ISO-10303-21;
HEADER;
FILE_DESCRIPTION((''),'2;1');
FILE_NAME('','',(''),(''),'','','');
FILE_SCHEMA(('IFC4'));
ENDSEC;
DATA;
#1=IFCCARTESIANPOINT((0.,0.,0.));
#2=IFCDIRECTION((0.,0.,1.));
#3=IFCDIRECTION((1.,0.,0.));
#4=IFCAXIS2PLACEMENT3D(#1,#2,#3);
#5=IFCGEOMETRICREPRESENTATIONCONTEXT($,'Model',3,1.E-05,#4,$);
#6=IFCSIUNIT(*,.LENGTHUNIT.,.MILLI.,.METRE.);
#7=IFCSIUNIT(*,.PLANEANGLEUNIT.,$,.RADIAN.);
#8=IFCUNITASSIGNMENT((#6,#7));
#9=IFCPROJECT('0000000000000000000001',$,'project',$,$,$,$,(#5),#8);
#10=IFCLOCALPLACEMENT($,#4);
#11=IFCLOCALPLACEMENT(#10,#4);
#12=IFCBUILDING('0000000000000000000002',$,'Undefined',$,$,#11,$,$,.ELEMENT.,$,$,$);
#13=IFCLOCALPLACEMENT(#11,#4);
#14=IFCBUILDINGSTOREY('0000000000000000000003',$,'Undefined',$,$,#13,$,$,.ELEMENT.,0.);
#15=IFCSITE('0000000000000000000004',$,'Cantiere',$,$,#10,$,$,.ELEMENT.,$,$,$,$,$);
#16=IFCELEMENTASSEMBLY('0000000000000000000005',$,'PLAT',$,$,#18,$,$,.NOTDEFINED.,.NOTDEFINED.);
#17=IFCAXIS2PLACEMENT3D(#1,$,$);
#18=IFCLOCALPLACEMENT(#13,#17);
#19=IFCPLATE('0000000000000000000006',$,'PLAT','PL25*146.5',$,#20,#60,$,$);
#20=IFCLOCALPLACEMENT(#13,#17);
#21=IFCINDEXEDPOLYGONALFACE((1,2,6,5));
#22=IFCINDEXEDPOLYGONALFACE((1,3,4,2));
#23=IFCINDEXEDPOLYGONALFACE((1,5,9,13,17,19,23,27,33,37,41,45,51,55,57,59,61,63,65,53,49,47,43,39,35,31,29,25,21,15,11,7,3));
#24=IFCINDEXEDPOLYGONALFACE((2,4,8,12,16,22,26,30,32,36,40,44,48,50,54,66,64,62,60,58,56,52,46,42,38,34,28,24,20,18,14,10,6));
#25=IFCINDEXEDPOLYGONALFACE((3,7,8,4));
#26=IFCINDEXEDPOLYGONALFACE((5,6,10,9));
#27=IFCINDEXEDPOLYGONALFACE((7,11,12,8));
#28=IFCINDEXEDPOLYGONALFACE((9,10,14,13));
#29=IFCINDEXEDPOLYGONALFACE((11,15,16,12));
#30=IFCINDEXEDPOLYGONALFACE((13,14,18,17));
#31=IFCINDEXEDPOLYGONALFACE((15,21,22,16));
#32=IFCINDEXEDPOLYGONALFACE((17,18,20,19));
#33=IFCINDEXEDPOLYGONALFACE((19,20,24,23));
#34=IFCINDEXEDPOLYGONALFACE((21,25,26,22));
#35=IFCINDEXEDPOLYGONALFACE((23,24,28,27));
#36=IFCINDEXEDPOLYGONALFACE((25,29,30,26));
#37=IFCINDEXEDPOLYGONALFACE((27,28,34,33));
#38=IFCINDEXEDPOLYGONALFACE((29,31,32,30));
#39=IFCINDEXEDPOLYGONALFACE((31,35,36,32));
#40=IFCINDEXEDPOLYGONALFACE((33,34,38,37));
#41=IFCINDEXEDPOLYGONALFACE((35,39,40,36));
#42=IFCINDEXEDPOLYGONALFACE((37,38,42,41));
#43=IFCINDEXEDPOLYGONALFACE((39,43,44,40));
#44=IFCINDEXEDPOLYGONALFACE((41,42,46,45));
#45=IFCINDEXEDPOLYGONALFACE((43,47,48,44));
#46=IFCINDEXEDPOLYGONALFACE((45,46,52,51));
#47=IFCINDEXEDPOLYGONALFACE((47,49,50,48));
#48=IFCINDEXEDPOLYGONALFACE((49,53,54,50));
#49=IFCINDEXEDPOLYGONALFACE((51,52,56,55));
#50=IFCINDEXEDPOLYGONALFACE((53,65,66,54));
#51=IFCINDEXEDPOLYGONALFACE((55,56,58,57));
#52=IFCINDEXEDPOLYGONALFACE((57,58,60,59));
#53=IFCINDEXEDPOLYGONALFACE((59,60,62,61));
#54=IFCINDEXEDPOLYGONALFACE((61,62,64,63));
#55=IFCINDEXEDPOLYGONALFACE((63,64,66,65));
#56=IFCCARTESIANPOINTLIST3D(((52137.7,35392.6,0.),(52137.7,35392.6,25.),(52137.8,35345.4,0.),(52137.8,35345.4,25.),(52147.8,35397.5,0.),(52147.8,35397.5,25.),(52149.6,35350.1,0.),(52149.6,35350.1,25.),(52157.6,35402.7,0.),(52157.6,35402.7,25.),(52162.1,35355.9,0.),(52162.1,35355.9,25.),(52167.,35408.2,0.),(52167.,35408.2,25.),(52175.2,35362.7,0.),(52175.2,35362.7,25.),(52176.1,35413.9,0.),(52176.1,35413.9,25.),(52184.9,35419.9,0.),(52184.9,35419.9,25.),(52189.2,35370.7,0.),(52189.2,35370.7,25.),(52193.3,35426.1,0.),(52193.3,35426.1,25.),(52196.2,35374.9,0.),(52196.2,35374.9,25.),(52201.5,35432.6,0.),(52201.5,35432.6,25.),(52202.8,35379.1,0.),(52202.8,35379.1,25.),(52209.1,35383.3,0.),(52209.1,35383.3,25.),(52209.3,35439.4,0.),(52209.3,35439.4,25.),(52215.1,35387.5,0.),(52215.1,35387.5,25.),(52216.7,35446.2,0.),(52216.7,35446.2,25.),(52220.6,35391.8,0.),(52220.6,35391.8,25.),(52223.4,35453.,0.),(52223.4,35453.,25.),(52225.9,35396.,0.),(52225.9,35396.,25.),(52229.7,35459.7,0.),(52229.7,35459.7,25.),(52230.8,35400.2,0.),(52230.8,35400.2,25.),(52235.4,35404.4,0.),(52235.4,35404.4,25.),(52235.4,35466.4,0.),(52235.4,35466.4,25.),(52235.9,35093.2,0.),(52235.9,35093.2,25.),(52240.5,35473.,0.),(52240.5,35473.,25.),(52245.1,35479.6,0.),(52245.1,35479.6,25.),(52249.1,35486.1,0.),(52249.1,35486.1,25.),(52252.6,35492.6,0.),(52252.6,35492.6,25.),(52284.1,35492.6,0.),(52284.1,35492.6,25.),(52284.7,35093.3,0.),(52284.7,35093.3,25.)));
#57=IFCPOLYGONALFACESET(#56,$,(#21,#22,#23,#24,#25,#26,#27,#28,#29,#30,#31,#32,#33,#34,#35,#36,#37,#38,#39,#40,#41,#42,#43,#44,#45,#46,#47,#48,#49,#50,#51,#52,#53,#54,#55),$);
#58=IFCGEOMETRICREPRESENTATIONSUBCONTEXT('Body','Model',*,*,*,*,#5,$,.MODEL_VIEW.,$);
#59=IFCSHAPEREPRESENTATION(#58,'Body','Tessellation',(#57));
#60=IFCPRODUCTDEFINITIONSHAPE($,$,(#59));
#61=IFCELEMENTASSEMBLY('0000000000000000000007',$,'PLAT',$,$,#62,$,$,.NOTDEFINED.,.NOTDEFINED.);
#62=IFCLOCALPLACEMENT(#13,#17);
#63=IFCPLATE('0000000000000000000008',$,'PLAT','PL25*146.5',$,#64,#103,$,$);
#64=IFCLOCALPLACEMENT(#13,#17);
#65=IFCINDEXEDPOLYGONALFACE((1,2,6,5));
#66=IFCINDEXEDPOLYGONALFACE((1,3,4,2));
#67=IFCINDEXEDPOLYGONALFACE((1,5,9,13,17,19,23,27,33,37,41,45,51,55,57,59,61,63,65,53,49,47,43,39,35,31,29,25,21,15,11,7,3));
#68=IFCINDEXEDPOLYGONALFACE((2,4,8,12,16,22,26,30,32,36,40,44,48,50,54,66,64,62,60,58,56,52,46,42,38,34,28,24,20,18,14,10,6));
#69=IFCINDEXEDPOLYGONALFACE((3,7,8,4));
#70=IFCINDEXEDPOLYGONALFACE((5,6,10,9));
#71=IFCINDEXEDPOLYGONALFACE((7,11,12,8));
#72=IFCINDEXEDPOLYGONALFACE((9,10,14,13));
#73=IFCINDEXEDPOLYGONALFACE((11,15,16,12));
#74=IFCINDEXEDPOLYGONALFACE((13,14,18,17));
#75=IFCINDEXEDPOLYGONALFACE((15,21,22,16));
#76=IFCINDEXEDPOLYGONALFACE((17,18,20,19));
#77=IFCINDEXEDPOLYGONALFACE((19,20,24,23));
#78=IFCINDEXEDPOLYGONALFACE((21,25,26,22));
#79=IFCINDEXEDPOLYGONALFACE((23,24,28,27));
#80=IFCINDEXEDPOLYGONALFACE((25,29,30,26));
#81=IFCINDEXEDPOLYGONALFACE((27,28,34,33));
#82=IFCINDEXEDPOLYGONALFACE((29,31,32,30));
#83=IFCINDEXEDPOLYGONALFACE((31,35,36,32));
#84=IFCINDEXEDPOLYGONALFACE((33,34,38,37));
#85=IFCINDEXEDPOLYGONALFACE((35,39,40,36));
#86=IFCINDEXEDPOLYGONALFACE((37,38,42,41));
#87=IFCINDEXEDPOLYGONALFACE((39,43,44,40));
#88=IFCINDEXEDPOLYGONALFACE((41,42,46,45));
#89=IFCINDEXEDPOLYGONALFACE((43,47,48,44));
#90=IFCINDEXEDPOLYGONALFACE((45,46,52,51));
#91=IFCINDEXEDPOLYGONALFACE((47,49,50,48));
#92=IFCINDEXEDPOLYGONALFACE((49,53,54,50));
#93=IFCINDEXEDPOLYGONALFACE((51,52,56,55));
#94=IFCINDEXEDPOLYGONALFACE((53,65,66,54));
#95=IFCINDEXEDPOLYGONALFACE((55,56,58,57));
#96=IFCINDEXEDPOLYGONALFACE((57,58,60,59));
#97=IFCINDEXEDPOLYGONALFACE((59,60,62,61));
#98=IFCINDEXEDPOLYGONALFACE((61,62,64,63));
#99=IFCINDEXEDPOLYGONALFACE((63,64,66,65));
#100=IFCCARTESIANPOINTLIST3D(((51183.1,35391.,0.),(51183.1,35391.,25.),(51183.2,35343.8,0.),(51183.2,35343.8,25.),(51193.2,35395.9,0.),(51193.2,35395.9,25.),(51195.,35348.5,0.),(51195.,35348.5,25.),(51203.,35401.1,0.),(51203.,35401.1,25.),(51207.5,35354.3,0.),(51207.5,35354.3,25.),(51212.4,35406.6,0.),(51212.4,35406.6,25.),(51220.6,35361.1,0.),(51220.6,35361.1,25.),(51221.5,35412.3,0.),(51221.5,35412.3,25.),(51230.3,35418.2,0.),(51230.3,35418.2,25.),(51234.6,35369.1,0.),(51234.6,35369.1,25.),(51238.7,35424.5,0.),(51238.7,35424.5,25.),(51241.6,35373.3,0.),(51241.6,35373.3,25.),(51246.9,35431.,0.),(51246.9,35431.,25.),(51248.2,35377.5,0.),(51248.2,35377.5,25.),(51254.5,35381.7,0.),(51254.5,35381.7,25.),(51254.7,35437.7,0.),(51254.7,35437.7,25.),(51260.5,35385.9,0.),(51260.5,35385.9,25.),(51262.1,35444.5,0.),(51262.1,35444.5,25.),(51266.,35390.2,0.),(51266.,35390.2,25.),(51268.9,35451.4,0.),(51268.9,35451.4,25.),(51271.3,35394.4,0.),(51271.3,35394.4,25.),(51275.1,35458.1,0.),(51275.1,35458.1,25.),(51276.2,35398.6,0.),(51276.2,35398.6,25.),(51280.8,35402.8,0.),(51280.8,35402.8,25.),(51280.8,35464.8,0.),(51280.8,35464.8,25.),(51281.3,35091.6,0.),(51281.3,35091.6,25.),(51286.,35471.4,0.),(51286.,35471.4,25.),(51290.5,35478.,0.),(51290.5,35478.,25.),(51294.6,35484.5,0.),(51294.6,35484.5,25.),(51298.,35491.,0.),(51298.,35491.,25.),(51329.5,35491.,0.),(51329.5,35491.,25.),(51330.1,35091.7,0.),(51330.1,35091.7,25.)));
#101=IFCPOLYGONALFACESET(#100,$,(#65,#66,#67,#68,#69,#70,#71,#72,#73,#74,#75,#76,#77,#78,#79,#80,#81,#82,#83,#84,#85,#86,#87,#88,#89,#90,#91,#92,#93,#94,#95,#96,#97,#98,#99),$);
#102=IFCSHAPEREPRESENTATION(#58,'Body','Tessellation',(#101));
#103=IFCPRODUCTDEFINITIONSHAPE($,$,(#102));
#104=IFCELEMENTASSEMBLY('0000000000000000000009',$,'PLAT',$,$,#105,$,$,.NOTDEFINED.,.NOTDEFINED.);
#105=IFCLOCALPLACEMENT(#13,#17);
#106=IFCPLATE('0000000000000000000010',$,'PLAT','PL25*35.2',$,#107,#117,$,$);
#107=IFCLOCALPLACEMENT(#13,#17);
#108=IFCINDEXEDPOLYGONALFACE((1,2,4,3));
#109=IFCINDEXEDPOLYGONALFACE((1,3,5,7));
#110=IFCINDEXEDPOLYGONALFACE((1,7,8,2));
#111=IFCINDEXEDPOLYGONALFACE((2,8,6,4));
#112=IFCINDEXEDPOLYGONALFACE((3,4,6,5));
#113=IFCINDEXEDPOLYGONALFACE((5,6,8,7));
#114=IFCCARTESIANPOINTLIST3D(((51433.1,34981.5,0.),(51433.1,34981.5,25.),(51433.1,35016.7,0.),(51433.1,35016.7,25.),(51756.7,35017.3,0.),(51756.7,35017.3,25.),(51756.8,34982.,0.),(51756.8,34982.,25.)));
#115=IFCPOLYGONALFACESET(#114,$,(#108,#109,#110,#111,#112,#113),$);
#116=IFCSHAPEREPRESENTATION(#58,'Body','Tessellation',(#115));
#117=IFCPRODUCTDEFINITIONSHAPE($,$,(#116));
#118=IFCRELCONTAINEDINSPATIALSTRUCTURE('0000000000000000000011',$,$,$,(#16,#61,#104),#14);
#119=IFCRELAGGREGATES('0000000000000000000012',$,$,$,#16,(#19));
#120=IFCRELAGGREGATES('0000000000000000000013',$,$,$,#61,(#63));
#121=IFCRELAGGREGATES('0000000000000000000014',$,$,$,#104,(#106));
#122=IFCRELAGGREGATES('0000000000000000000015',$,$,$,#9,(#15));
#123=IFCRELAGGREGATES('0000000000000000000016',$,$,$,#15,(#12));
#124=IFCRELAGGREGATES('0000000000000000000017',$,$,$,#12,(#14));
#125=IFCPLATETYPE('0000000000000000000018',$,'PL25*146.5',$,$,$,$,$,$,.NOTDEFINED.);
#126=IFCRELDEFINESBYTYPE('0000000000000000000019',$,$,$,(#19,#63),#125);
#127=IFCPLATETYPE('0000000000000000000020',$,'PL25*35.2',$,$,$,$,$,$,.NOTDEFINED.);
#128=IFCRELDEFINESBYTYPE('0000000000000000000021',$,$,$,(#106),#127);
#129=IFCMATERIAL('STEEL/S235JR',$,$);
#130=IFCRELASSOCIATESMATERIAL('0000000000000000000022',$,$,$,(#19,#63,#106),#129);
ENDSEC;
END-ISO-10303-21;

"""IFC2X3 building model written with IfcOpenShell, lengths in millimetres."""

from ifc_helpers import new_model, si_unit, frame, origin_with_axes, place, context, subcontext, project, spatial, polyline, outline, extrude, material, type_object, element, aggregate, save


model = new_model("IFC2X3")

# Units and contexts
model_context = context("Model", 3, precision=1e-05, world=origin_with_axes())
body_context = subcontext(model_context, "Body", "Model", "MODEL_VIEW")
ifc_project = project(units=[si_unit("LENGTHUNIT", "METRE", prefix="MILLI"), si_unit("PLANEANGLEUNIT", "RADIAN")], contexts=[model_context])

# Site, building, storey
site_placement = place(None, origin_with_axes())
site = spatial("IfcSite", under=ifc_project, at=site_placement, Name="Cantiere", CompositionType="ELEMENT")
building_placement = place(site_placement, origin_with_axes())
building = spatial("IfcBuilding", under=site, at=building_placement, Name="Undefined", CompositionType="ELEMENT")
storey_placement = place(building_placement, origin_with_axes())
storey = spatial("IfcBuildingStorey", under=building, at=storey_placement, Name="Undefined", CompositionType="ELEMENT", Elevation=0.0)

# Shared definitions
ifc_material_1 = material(Name="STEEL/S235JR")

# Element assemblies, plates
assembly_1_placement = place(storey_placement, origin_with_axes())
assembly_1 = element("IfcElementAssembly", 1, at=assembly_1_placement, inside=storey, Name="PLAT", AssemblyPlace="NOTDEFINED", PredefinedType="NOTDEFINED")
plate_type_1 = type_object("IfcPlateType", Name="PL25*146.5", PredefinedType="NOTDEFINED")
plate_1_placement = place(assembly_1_placement, frame((52284.7, 35093.3, 12.5), z_axis=(0.0, 0.000001, -1.0), x_axis=(-0.999999, -0.001693, 0.0)))
plate_1 = element("IfcPlate", 2, at=plate_1_placement, type_object=plate_type_1, material=ifc_material_1, Name="PLAT", Description="PL25*146.5", context=body_context, shape_type="SweptSolid", body=[
    extrude(outline(polyline([(0.0, 0.0), (48.8, 0.0), (48.8, 311.2), (53.4, 307.0), (58.3, 302.8), (63.6, 298.6), (69.2, 294.3), (75.1, 290.1), (81.4, 285.9), (88.1, 281.7), (95.1, 277.5), (109.0, 269.6), (122.3, 262.8), (134.8, 257.0), (146.5, 252.3), (146.5, 299.5), (136.4, 304.5), (126.6, 309.6), (117.2, 315.1), (108.1, 320.8), (99.3, 326.7), (90.8, 333.0), (82.7, 339.4), (74.9, 346.2), (67.5, 353.0), (60.7, 359.8), (54.4, 366.5), (48.7, 373.2), (43.6, 379.8), (39.0, 386.4), (34.9, 392.9), (31.5, 399.3), (0.0, 399.3), (0.0, 0.0)])), frame((0.0, 0.0, -12.5), z_axis=(0.0, 0.0, 1.0), x_axis=(1.0, 0.0, 0.0)), (0.0, 0.0, 1.0), 25.0),
])
aggregate(assembly_1, [plate_1])
assembly_2_placement = place(storey_placement, origin_with_axes())
assembly_2 = element("IfcElementAssembly", 3, at=assembly_2_placement, inside=storey, Name="PLAT", AssemblyPlace="NOTDEFINED", PredefinedType="NOTDEFINED")
plate_2_placement = place(assembly_2_placement, frame((51330.1, 35091.7, 12.5), z_axis=(0.0, 0.000001, -1.0), x_axis=(-0.999999, -0.001693, 0.0)))
plate_2 = element("IfcPlate", 4, at=plate_2_placement, type_object=plate_type_1, material=ifc_material_1, Name="PLAT", Description="PL25*146.5", context=body_context, shape_type="SweptSolid", body=[
    extrude(outline(polyline([(0.0, 0.0), (48.9, 0.0), (48.9, 311.2), (53.5, 307.0), (58.4, 302.7), (63.6, 298.6), (69.2, 294.3), (75.1, 290.1), (81.5, 285.9), (88.1, 281.7), (95.1, 277.5), (109.0, 269.6), (122.3, 262.8), (134.8, 257.0), (146.5, 252.3), (146.5, 299.5), (136.4, 304.5), (126.7, 309.6), (117.2, 315.1), (108.1, 320.7), (99.3, 326.7), (90.9, 333.0), (82.7, 339.4), (74.9, 346.2), (67.5, 353.0), (60.6, 359.8), (54.4, 366.5), (48.7, 373.2), (43.5, 379.8), (39.0, 386.4), (34.9, 392.9), (31.5, 399.3), (0.0, 399.3), (0.0, 0.0)])), frame((0.0, 0.0, -12.5), z_axis=(0.0, 0.0, 1.0), x_axis=(1.0, 0.0, 0.0)), (0.0, 0.0, 1.0), 25.0),
])
aggregate(assembly_2, [plate_2])
assembly_3_placement = place(storey_placement, origin_with_axes())
assembly_3 = element("IfcElementAssembly", 5, at=assembly_3_placement, inside=storey, Name="PLAT", AssemblyPlace="NOTDEFINED", PredefinedType="NOTDEFINED")
plate_type_2 = type_object("IfcPlateType", Name="PL25*35.2", PredefinedType="NOTDEFINED")
plate_3_placement = place(assembly_3_placement, frame((51433.1, 34981.5, 12.5), z_axis=(0.0, 0.000001, -1.0), x_axis=(-0.001693, 0.999999, 0.0)))
plate_3 = element("IfcPlate", 6, at=plate_3_placement, type_object=plate_type_2, material=ifc_material_1, Name="PLAT", Description="PL25*35.2", context=body_context, shape_type="SweptSolid", body=[
    extrude(outline(polyline([(0.0, 0.0), (35.2, 0.0), (35.2, 323.7), (0.0, 323.7), (0.0, 0.0)])), frame((0.0, 0.0, -12.5), z_axis=(0.0, 0.0, 1.0), x_axis=(1.0, 0.0, 0.0)), (0.0, 0.0, 1.0), 25.0),
])
aggregate(assembly_3, [plate_3])

save(model, "model.ifc")
